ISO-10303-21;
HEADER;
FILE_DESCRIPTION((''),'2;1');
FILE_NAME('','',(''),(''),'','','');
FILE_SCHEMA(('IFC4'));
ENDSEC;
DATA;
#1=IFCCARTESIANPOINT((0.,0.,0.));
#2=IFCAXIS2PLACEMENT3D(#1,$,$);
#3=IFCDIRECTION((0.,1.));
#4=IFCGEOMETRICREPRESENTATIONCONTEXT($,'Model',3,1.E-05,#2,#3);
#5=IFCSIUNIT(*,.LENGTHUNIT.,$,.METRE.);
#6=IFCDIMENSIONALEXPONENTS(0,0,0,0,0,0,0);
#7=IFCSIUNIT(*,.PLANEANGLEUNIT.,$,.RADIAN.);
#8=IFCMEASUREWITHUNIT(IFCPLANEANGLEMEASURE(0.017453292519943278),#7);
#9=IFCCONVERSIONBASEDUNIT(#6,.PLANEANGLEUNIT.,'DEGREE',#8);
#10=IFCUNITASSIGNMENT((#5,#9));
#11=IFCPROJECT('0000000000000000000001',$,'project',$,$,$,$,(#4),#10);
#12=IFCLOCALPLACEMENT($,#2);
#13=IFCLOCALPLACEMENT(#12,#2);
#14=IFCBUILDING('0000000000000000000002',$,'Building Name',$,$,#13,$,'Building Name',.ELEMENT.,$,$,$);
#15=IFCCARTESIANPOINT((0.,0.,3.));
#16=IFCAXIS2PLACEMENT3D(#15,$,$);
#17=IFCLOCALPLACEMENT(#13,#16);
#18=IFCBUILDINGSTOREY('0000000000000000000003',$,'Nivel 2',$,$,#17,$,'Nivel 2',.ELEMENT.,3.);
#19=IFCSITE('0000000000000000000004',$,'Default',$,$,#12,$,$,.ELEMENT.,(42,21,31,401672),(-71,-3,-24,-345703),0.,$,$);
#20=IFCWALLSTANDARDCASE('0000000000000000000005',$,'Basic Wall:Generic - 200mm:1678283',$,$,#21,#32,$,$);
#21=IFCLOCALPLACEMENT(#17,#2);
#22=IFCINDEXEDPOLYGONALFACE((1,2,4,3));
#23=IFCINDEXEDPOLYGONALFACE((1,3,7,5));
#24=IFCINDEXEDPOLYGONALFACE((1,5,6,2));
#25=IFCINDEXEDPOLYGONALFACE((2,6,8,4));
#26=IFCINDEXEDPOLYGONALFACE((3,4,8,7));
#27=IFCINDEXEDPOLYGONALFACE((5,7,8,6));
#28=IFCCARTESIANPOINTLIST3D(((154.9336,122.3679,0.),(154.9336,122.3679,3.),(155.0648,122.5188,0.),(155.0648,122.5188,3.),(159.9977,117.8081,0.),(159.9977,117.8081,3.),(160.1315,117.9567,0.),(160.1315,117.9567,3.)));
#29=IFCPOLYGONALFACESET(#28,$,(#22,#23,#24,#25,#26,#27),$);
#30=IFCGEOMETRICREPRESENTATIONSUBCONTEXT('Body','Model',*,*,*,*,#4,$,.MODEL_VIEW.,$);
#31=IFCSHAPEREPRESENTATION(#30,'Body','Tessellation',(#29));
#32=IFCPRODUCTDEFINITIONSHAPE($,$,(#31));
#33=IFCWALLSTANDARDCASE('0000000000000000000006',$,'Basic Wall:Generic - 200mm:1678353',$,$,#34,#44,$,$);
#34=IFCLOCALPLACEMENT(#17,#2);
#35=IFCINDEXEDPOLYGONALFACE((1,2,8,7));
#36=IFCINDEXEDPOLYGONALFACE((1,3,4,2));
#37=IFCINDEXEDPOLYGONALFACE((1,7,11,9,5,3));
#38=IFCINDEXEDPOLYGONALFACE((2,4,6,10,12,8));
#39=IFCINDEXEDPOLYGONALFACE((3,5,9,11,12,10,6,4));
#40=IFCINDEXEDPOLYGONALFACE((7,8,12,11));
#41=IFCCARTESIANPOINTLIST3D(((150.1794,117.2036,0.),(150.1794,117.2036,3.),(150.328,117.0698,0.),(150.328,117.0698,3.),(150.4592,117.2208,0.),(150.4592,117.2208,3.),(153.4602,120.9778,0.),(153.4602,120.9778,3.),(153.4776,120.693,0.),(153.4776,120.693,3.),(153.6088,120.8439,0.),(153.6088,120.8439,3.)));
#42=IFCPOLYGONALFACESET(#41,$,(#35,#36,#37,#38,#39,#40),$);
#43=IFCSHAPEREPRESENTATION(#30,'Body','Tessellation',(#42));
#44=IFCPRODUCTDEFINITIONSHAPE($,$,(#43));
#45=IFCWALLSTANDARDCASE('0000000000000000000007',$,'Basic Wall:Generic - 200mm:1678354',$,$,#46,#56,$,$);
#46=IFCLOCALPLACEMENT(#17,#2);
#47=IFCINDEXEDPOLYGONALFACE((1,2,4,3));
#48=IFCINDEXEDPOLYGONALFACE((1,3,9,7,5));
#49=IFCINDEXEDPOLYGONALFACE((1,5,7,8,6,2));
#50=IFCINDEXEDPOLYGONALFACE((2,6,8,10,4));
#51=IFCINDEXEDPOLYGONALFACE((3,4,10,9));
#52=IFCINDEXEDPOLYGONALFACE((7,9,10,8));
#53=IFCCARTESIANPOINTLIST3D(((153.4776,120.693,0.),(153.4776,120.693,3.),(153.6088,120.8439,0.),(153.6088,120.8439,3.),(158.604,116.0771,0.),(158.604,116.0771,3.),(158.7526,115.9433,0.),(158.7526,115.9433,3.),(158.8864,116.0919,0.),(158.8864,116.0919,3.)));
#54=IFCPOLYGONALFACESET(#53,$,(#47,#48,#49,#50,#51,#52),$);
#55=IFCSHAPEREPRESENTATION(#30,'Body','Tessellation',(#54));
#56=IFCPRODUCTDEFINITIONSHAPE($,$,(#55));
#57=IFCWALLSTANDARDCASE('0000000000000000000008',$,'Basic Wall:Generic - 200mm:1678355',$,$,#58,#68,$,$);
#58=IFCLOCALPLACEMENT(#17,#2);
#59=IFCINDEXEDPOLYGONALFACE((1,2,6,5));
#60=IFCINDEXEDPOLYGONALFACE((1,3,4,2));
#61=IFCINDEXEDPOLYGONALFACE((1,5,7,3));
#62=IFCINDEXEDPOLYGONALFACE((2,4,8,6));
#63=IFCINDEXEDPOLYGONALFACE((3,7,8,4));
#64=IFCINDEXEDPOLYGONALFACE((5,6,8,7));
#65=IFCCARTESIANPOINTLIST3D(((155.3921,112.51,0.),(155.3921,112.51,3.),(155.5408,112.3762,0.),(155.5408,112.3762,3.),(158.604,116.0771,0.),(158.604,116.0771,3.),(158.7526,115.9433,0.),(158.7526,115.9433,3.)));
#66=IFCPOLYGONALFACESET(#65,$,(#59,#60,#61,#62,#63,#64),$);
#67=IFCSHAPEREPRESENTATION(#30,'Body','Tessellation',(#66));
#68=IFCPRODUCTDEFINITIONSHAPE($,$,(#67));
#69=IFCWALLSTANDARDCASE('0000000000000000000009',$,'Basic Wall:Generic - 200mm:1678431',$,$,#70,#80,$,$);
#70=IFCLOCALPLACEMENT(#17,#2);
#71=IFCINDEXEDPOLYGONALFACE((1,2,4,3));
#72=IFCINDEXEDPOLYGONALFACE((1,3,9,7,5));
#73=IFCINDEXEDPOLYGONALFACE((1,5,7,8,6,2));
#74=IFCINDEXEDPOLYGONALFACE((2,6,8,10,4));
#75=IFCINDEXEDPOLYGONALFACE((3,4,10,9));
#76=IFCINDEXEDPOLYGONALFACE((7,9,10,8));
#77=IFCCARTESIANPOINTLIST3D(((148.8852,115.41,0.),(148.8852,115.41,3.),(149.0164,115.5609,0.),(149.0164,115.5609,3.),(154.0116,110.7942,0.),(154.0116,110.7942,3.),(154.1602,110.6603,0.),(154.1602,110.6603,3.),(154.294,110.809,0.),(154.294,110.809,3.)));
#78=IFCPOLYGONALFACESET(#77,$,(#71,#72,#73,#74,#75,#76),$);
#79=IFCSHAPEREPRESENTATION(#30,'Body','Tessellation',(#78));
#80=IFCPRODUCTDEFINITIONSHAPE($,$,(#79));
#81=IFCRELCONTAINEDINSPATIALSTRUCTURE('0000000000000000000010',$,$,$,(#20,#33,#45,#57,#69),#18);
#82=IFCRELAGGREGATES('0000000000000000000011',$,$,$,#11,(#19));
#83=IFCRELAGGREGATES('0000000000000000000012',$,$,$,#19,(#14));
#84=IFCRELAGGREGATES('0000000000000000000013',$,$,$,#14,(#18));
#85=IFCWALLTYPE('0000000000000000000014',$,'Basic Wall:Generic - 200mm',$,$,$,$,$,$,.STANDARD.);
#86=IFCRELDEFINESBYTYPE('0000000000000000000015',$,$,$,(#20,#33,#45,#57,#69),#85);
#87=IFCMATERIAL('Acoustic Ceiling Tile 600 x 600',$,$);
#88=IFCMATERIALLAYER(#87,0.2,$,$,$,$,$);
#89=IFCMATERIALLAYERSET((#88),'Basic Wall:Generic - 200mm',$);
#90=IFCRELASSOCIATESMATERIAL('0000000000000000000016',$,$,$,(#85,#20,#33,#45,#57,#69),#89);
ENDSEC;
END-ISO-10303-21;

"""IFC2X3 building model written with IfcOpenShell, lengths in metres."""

from ifc_helpers import new_model, entity, si_unit, converted_unit, direction, frame, frame_2d, origin, place, context, subcontext, project, spatial, polyline, rectangle, outline, extrude, material, layer, layer_set, layer_usage, type_object, element, save


model = new_model("IFC2X3")

# Units and contexts
model_context = context("Model", 3, precision=1e-05, world=origin(), true_north=direction((0.0, 1.0)))
body_context = subcontext(model_context, "Body", "Model", "MODEL_VIEW")
ifc_project = project(units=[si_unit("LENGTHUNIT", "METRE"), converted_unit("PLANEANGLEUNIT", "DEGREE", entity("IfcPlaneAngleMeasure", 0.017453292519943278), si_unit("PLANEANGLEUNIT", "RADIAN"), dimensions=[0, 0, 0, 0, 0, 0, 0])], contexts=[model_context])

# Site, building, storey
site_placement = place(None, origin())
site = spatial("IfcSite", under=ifc_project, at=site_placement, Name="Default", CompositionType="ELEMENT", RefLatitude=(42, 21, 31, 401672), RefLongitude=(-71, -3, -24, -345703), RefElevation=0.0)
building_placement = place(site_placement, origin())
building = spatial("IfcBuilding", under=site, at=building_placement, Name="Building Name", LongName="Building Name", CompositionType="ELEMENT")
storey_placement = place(building_placement, frame((0.0, 0.0, 3.0)))
storey = spatial("IfcBuildingStorey", under=building, at=storey_placement, Name="Nivel 2", LongName="Nivel 2", CompositionType="ELEMENT", Elevation=3.0)

# Shared definitions
ifc_material_1 = material(Name="Acoustic Ceiling Tile 600 x 600")
ifc_layer = layer(ifc_material_1, 0.2)
ifc_layer_set = layer_set([ifc_layer], Name="Basic Wall:Generic - 200mm")
wall_type_1 = type_object("IfcWallType", Name="Basic Wall:Generic - 200mm", PredefinedType="STANDARD", material=ifc_layer_set)

# Walls
ifc_layer_usage_1 = layer_usage(ifc_layer_set, "AXIS2", "NEGATIVE", 0.1)
wall_1_placement = place(storey_placement, frame((160.0646, 117.8824, 0.0), z_axis=(0.0, 0.0, 1.0), x_axis=(-0.743145, 0.669131, 0.0)))
element("IfcWallStandardCase", 1, at=wall_1_placement, inside=storey, type_object=wall_type_1, material=ifc_layer_usage_1, Name="Basic Wall:Generic - 200mm:1678283", context=body_context, shape_type="SweptSolid", body=[
    extrude(outline(polyline([(6.8179, -0.1), (6.8145, 0.1), (0.0, 0.1), (0.0, -0.1), (6.8179, -0.1)])), origin(), (0.0, 0.0, 1.0), 3.0),
])
ifc_layer_usage_2 = layer_usage(ifc_layer_set, "AXIS2", "NEGATIVE", 0.1)
wall_2_placement = place(storey_placement, frame((150.2525, 117.1354, 0.0), z_axis=(0.0, 0.0, 1.0), x_axis=(0.656059, 0.75471, 0.0)))
element("IfcWallStandardCase", 2, at=wall_2_placement, inside=storey, type_object=wall_type_1, material=ifc_layer_usage_2, Name="Basic Wall:Generic - 200mm:1678353", context=body_context, shape_type="SweptSolid", body=[
    extrude(outline(polyline([(5.0008, -0.1), (5.0043, 0.1), (0.0035, 0.1), (0.0, -0.1), (0.2, -0.1), (4.8007, -0.1), (5.0008, -0.1)])), origin(), (0.0, 0.0, 1.0), 3.0),
])
ifc_layer_usage_3 = layer_usage(ifc_layer_set, "AXIS2", "NEGATIVE", 0.1)
wall_3_placement = place(storey_placement, frame((153.5419, 120.7696, 0.0), z_axis=(0.0, 0.0, 1.0), x_axis=(0.743145, -0.669131, 0.0)))
element("IfcWallStandardCase", 3, at=wall_3_placement, inside=storey, type_object=wall_type_1, material=ifc_layer_usage_3, Name="Basic Wall:Generic - 200mm:1678354", context=body_context, shape_type="SweptSolid", body=[
    extrude(outline(polyline([(7.1017, -0.1), (7.1017, 0.1), (0.0, 0.1), (0.0035, -0.1), (6.9017, -0.1), (7.1017, -0.1)])), origin(), (0.0, 0.0, 1.0), 3.0),
])
ifc_layer_usage_4 = layer_usage(ifc_layer_set, "AXIS2", "NEGATIVE", 0.1)
wall_4_placement = place(storey_placement, frame((158.6783, 116.0102, 0.0), z_axis=(0.0, 0.0, 1.0), x_axis=(-0.669131, -0.743145, 0.0)))
element("IfcWallStandardCase", 4, at=wall_4_placement, inside=storey, type_object=wall_type_1, material=ifc_layer_usage_4, Name="Basic Wall:Generic - 200mm:1678355", context=body_context, shape_type="SweptSolid", body=[
    extrude(rectangle(XDim=4.8, YDim=0.2, at=frame_2d((2.4, 0.0), x_axis=(-1.0, 0.0))), origin(), (0.0, 0.0, 1.0), 3.0),
])
ifc_layer_usage_5 = layer_usage(ifc_layer_set, "AXIS2", "NEGATIVE", 0.1)
wall_5_placement = place(storey_placement, frame((148.9495, 115.4866, 0.0), z_axis=(0.0, 0.0, 1.0), x_axis=(0.743145, -0.669131, 0.0)))
element("IfcWallStandardCase", 5, at=wall_5_placement, inside=storey, type_object=wall_type_1, material=ifc_layer_usage_5, Name="Basic Wall:Generic - 200mm:1678431", context=body_context, shape_type="SweptSolid", body=[
    extrude(outline(polyline([(7.1017, -0.1), (7.1017, 0.1), (0.0, 0.1), (0.0035, -0.1), (6.9017, -0.1), (7.1017, -0.1)])), origin(), (0.0, 0.0, 1.0), 3.0),
])

save(model, "model.ifc")
